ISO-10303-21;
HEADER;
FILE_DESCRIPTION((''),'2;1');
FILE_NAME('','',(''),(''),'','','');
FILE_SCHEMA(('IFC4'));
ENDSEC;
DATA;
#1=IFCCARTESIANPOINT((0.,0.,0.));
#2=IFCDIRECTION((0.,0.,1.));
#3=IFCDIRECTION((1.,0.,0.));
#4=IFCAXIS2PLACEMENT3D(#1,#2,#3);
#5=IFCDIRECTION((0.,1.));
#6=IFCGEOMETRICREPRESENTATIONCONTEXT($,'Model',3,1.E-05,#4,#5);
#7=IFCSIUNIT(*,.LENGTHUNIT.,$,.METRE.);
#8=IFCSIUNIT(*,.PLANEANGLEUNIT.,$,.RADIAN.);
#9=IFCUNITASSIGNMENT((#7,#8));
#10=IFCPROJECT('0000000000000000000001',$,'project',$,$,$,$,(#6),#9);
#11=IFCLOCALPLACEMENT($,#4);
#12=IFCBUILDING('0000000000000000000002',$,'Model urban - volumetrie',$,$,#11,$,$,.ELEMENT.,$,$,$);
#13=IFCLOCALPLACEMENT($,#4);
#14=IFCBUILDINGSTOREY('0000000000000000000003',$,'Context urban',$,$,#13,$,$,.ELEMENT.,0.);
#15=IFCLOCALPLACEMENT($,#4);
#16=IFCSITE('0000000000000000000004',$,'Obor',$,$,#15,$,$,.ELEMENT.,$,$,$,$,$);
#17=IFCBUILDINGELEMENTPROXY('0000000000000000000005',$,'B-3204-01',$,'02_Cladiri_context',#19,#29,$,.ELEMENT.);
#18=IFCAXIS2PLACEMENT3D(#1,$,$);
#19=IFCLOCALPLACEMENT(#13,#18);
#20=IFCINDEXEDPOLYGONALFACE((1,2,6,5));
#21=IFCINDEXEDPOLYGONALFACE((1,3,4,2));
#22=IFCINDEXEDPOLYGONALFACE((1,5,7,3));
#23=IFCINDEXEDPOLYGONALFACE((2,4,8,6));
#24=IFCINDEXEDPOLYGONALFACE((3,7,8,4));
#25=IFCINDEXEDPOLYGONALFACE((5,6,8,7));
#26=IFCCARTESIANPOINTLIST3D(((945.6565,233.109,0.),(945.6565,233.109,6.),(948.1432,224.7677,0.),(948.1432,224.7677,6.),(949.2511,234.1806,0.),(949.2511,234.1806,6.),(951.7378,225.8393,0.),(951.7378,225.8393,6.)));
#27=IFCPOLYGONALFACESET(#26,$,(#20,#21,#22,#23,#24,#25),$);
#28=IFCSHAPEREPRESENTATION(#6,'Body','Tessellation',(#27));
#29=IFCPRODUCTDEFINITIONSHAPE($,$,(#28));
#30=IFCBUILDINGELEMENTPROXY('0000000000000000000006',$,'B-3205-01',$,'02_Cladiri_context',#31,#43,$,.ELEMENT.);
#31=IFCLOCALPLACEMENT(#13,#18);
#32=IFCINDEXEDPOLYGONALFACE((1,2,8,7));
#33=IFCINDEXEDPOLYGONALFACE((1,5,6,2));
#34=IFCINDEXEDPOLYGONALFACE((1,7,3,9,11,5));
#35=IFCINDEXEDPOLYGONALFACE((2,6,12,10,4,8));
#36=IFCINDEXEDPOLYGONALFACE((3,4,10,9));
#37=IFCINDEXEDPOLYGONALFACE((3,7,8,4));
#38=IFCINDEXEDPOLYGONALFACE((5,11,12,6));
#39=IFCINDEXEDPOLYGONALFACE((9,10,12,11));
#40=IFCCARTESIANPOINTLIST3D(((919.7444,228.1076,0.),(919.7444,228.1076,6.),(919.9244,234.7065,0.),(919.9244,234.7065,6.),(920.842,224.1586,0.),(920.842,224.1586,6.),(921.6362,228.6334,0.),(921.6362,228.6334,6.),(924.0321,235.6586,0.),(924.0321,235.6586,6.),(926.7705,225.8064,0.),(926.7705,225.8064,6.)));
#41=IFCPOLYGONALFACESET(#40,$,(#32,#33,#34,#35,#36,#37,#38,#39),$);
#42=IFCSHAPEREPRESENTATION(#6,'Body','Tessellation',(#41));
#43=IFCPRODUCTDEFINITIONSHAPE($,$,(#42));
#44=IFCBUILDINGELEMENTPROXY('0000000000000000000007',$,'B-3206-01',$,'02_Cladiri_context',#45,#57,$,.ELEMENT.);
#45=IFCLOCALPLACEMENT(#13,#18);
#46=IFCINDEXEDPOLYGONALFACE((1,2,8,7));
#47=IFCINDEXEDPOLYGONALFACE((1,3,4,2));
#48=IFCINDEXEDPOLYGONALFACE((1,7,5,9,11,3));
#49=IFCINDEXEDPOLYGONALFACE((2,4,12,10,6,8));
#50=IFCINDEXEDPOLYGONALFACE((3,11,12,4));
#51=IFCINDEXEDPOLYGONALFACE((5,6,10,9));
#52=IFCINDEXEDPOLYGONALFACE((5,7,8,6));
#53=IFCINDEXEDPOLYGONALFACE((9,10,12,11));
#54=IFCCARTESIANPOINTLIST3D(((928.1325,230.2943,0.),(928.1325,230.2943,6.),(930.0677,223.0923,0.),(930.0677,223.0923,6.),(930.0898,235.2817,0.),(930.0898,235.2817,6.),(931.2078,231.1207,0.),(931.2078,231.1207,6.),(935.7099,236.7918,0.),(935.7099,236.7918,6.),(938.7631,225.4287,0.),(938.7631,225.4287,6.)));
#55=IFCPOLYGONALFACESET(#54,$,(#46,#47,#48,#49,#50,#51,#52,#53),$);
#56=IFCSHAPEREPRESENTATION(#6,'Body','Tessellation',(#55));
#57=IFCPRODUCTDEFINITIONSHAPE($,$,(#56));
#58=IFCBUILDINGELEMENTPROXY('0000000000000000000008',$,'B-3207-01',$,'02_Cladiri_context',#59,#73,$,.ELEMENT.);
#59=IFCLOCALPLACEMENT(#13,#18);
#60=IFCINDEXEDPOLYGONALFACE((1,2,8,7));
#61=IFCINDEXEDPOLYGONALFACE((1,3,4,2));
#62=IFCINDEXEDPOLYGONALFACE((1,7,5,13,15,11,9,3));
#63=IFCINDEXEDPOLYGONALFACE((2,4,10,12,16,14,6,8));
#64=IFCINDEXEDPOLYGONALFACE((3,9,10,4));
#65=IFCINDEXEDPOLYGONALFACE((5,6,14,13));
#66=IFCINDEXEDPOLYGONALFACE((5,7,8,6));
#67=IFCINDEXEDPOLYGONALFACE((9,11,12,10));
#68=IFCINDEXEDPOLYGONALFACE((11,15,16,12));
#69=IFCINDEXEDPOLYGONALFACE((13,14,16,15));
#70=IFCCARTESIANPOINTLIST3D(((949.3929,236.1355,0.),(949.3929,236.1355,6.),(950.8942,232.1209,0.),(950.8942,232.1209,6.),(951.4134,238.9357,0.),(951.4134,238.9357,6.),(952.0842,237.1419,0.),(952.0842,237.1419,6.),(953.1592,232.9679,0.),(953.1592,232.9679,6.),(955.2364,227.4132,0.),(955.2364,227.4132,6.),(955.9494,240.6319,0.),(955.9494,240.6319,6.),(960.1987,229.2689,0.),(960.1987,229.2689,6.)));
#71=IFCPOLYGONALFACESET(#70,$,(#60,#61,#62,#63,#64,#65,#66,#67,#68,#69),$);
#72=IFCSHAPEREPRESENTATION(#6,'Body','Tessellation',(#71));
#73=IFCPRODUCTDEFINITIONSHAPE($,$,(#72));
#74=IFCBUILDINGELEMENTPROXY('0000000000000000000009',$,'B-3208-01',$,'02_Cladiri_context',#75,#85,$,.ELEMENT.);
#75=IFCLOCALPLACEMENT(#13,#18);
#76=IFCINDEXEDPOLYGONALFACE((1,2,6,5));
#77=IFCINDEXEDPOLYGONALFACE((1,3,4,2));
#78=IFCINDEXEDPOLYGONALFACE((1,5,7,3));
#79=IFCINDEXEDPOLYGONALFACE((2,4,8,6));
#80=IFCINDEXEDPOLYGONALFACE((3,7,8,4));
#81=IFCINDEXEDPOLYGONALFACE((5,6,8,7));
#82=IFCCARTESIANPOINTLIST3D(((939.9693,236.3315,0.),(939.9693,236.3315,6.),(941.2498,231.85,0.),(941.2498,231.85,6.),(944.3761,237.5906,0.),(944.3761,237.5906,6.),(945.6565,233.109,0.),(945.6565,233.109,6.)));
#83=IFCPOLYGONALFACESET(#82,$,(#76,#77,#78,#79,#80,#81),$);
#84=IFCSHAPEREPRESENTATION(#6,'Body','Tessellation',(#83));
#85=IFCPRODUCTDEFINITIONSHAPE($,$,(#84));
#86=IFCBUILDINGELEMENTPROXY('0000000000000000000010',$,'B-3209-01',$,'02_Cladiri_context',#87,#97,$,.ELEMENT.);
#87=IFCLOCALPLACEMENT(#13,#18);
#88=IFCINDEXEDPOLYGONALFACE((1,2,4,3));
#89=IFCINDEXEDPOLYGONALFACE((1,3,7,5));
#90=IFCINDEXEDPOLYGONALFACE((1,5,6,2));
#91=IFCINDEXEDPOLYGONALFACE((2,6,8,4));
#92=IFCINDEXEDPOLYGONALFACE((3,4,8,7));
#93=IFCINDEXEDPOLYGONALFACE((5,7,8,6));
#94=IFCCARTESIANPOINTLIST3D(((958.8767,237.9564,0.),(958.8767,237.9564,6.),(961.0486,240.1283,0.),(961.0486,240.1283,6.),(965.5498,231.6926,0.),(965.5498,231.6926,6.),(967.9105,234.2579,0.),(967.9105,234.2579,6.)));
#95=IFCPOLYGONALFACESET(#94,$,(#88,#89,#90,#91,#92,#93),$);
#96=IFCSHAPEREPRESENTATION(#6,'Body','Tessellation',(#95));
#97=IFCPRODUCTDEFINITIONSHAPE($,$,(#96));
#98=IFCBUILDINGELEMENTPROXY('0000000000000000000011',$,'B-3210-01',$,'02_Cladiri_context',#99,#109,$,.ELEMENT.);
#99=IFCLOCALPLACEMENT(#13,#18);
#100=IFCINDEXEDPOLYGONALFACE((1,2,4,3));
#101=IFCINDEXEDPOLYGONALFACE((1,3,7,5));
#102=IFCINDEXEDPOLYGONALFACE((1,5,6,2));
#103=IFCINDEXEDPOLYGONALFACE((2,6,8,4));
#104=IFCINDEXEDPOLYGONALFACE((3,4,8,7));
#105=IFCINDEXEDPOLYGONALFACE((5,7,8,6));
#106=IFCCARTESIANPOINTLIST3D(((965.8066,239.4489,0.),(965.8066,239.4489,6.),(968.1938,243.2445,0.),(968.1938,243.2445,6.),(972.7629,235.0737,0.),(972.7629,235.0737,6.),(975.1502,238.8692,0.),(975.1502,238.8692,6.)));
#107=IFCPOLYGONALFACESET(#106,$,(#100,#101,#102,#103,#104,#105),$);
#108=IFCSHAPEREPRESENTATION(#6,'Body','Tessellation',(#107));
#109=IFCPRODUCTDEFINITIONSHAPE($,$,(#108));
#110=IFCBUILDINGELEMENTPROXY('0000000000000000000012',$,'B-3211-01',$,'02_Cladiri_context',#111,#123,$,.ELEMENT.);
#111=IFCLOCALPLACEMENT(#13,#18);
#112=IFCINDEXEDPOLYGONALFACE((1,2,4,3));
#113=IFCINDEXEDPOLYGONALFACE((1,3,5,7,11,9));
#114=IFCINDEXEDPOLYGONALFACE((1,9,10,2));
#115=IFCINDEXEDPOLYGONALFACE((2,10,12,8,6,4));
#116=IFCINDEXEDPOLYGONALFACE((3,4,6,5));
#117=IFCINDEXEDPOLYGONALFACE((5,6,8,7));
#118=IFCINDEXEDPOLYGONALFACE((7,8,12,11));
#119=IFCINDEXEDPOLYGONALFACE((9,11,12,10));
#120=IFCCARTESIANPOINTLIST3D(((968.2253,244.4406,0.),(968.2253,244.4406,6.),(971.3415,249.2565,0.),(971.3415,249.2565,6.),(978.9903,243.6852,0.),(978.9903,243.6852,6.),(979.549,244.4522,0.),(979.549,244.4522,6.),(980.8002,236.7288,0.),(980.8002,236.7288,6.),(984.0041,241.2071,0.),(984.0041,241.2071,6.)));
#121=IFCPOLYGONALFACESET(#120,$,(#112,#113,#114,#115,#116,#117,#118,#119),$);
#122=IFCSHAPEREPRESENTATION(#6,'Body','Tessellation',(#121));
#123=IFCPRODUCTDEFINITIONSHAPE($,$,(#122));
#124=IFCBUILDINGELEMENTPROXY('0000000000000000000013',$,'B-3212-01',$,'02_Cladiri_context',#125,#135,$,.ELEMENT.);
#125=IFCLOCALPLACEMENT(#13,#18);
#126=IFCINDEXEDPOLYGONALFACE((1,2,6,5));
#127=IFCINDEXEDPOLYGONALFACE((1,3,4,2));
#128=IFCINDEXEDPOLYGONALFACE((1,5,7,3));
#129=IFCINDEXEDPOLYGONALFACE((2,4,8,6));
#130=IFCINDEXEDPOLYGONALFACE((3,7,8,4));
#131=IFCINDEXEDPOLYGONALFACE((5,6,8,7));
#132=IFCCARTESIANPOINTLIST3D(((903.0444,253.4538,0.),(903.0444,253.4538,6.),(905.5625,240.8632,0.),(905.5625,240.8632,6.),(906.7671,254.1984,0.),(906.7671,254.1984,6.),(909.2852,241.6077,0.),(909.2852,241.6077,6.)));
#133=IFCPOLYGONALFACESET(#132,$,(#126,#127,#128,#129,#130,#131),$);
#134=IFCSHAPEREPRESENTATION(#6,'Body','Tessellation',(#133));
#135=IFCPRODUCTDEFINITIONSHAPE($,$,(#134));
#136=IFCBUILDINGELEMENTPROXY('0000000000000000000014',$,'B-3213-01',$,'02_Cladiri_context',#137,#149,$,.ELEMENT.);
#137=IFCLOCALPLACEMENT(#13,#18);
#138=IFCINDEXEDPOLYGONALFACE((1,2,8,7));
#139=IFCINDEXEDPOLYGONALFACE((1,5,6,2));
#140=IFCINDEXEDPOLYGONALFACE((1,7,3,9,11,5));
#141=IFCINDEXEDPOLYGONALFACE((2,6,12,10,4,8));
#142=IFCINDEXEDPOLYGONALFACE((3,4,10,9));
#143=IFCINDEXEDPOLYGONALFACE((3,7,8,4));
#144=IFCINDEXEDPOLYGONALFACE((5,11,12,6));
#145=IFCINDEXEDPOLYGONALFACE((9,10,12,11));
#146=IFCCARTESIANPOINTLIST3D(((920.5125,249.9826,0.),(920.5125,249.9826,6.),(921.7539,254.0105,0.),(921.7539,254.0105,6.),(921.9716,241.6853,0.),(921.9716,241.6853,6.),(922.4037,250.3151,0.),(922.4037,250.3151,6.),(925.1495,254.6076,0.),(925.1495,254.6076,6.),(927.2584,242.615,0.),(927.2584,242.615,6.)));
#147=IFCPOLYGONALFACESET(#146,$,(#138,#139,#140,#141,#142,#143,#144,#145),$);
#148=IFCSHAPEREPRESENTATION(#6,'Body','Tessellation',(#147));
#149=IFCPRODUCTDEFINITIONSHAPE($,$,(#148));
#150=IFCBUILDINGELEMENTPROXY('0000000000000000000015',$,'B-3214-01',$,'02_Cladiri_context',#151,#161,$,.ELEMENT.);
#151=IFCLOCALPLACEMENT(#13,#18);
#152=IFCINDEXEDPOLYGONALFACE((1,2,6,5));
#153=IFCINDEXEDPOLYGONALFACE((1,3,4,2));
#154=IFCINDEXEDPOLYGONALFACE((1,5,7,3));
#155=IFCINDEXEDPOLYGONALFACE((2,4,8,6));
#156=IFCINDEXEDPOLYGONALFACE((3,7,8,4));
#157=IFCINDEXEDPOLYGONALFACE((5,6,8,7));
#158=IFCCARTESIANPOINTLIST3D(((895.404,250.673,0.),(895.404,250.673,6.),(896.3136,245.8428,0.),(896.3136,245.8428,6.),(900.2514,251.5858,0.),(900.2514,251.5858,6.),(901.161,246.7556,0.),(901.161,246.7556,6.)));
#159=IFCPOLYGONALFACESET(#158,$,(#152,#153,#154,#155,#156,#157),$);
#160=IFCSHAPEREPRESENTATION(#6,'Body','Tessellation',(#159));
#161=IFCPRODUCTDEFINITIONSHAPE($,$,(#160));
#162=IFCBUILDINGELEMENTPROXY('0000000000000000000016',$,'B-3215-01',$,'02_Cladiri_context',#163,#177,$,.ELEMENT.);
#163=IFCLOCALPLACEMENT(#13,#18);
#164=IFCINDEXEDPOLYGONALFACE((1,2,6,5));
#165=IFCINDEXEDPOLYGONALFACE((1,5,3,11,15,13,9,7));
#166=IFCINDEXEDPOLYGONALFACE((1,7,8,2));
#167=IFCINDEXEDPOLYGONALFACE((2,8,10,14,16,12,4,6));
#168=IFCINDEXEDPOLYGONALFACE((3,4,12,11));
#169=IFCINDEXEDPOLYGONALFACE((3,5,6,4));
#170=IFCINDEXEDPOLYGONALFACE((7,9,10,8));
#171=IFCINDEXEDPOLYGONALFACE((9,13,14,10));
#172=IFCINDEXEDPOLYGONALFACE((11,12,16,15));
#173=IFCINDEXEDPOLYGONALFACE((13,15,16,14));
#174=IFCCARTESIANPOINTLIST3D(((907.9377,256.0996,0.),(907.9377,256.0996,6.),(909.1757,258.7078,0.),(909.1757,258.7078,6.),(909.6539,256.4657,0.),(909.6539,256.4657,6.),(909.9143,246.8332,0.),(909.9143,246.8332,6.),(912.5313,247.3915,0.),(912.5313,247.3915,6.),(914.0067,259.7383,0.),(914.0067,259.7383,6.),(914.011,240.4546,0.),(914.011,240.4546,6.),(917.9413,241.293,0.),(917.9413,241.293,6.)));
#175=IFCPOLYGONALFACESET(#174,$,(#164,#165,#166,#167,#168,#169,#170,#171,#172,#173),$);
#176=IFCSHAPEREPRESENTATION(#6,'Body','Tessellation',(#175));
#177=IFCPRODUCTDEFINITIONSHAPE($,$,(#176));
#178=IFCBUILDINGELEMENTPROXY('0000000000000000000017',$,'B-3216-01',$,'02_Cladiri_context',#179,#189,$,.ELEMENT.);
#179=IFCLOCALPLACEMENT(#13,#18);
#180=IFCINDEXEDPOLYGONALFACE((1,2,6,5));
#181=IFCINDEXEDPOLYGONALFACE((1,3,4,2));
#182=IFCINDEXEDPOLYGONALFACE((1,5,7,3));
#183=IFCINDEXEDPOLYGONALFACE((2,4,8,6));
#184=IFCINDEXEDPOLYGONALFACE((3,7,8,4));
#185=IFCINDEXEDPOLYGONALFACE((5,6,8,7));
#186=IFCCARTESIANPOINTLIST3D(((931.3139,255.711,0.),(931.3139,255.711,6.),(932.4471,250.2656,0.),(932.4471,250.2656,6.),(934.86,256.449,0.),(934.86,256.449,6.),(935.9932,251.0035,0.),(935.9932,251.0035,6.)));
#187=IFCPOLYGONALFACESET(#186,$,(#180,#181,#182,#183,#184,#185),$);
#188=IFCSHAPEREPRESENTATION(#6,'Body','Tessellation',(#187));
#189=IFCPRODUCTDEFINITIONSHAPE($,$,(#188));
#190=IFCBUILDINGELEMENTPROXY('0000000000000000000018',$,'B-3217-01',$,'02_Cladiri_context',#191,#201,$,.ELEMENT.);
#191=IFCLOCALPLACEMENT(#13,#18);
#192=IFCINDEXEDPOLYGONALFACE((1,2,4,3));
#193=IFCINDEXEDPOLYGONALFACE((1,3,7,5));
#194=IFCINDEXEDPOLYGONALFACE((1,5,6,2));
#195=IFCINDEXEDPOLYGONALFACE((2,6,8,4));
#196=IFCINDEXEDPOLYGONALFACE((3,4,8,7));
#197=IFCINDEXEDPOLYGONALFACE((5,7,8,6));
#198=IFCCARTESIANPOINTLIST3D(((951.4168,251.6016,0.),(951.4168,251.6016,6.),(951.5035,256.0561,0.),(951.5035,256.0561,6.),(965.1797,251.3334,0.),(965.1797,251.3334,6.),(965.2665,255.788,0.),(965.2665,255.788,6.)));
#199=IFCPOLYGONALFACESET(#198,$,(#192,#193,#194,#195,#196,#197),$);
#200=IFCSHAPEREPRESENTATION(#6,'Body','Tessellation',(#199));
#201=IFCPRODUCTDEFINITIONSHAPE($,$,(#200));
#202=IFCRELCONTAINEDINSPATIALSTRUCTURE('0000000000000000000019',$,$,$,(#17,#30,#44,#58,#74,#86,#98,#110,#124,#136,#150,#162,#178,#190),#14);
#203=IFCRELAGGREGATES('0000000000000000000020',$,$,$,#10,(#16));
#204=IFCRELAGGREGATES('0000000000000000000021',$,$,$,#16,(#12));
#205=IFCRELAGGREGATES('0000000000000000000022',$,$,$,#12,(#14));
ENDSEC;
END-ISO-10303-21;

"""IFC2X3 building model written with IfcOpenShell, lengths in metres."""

from ifc_helpers import new_model, si_unit, direction, origin_with_axes, place, context, project, spatial, polyline, outline, extrude, element, save


model = new_model("IFC2X3")

# Units and contexts
model_context = context("Model", 3, precision=1e-05, world=origin_with_axes(), true_north=direction((0.0, 1.0)))
ifc_project = project(units=[si_unit("LENGTHUNIT", "METRE"), si_unit("PLANEANGLEUNIT", "RADIAN")], contexts=[model_context])

# Site, building, storey
site_placement = place(None, origin_with_axes())
site = spatial("IfcSite", under=ifc_project, at=site_placement, Name="Obor", CompositionType="ELEMENT")
building_placement = place(None, origin_with_axes())
building = spatial("IfcBuilding", under=site, at=building_placement, Name="Model urban - volumetrie", CompositionType="ELEMENT")
storey_placement = place(None, origin_with_axes())
storey = spatial("IfcBuildingStorey", under=building, at=storey_placement, Name="Context urban", CompositionType="ELEMENT", Elevation=0.0)

# Building element proxies
proxy_1_placement = place(None, origin_with_axes())
element("IfcBuildingElementProxy", 1, at=proxy_1_placement, inside=storey, Name="B-3204-01", ObjectType="02_Cladiri_context", CompositionType="ELEMENT", context=model_context, shape_type="SweptSolid", body=[
    extrude(outline(polyline([(951.7378, 225.8393), (949.2511, 234.1806), (945.6565, 233.109), (948.1432, 224.7677), (951.7378, 225.8393)])), origin_with_axes(), (0.0, 0.0, 1.0), 6.0),
])
proxy_2_placement = place(None, origin_with_axes())
element("IfcBuildingElementProxy", 2, at=proxy_2_placement, inside=storey, Name="B-3205-01", ObjectType="02_Cladiri_context", CompositionType="ELEMENT", context=model_context, shape_type="SweptSolid", body=[
    extrude(outline(polyline([(920.842, 224.1586), (926.7705, 225.8064), (924.0321, 235.6586), (919.9244, 234.7065), (921.6362, 228.6334), (919.7444, 228.1076), (920.842, 224.1586)])), origin_with_axes(), (0.0, 0.0, 1.0), 6.0),
])
proxy_3_placement = place(None, origin_with_axes())
element("IfcBuildingElementProxy", 3, at=proxy_3_placement, inside=storey, Name="B-3206-01", ObjectType="02_Cladiri_context", CompositionType="ELEMENT", context=model_context, shape_type="SweptSolid", body=[
    extrude(outline(polyline([(928.1325, 230.2943), (930.0677, 223.0923), (938.7631, 225.4287), (935.7099, 236.7918), (930.0898, 235.2817), (931.2078, 231.1207), (928.1325, 230.2943)])), origin_with_axes(), (0.0, 0.0, 1.0), 6.0),
])
proxy_4_placement = place(None, origin_with_axes())
element("IfcBuildingElementProxy", 4, at=proxy_4_placement, inside=storey, Name="B-3207-01", ObjectType="02_Cladiri_context", CompositionType="ELEMENT", context=model_context, shape_type="SweptSolid", body=[
    extrude(outline(polyline([(951.4134, 238.9357), (952.0842, 237.1419), (949.3929, 236.1355), (950.8942, 232.1209), (953.1592, 232.9679), (955.2364, 227.4132), (960.1987, 229.2689), (955.9494, 240.6319), (951.4134, 238.9357)])), origin_with_axes(), (0.0, 0.0, 1.0), 6.0),
])
proxy_5_placement = place(None, origin_with_axes())
element("IfcBuildingElementProxy", 5, at=proxy_5_placement, inside=storey, Name="B-3208-01", ObjectType="02_Cladiri_context", CompositionType="ELEMENT", context=model_context, shape_type="SweptSolid", body=[
    extrude(outline(polyline([(939.9693, 236.3315), (941.2498, 231.85), (945.6565, 233.109), (944.3761, 237.5906), (939.9693, 236.3315)])), origin_with_axes(), (0.0, 0.0, 1.0), 6.0),
])
proxy_6_placement = place(None, origin_with_axes())
element("IfcBuildingElementProxy", 6, at=proxy_6_placement, inside=storey, Name="B-3209-01", ObjectType="02_Cladiri_context", CompositionType="ELEMENT", context=model_context, shape_type="SweptSolid", body=[
    extrude(outline(polyline([(967.9105, 234.2579), (961.0486, 240.1283), (958.8767, 237.9564), (965.5498, 231.6926), (967.9105, 234.2579)])), origin_with_axes(), (0.0, 0.0, 1.0), 6.0),
])
proxy_7_placement = place(None, origin_with_axes())
element("IfcBuildingElementProxy", 7, at=proxy_7_placement, inside=storey, Name="B-3210-01", ObjectType="02_Cladiri_context", CompositionType="ELEMENT", context=model_context, shape_type="SweptSolid", body=[
    extrude(outline(polyline([(972.7629, 235.0737), (975.1502, 238.8692), (968.1938, 243.2445), (965.8066, 239.4489), (972.7629, 235.0737)])), origin_with_axes(), (0.0, 0.0, 1.0), 6.0),
])
proxy_8_placement = place(None, origin_with_axes())
element("IfcBuildingElementProxy", 8, at=proxy_8_placement, inside=storey, Name="B-3211-01", ObjectType="02_Cladiri_context", CompositionType="ELEMENT", context=model_context, shape_type="SweptSolid", body=[
    extrude(outline(polyline([(984.0041, 241.2071), (979.549, 244.4522), (978.9903, 243.6852), (971.3415, 249.2565), (968.2253, 244.4406), (980.8002, 236.7288), (984.0041, 241.2071)])), origin_with_axes(), (0.0, 0.0, 1.0), 6.0),
])
proxy_9_placement = place(None, origin_with_axes())
element("IfcBuildingElementProxy", 9, at=proxy_9_placement, inside=storey, Name="B-3212-01", ObjectType="02_Cladiri_context", CompositionType="ELEMENT", context=model_context, shape_type="SweptSolid", body=[
    extrude(outline(polyline([(903.0444, 253.4538), (905.5625, 240.8632), (909.2852, 241.6077), (906.7671, 254.1984), (903.0444, 253.4538)])), origin_with_axes(), (0.0, 0.0, 1.0), 6.0),
])
proxy_10_placement = place(None, origin_with_axes())
element("IfcBuildingElementProxy", 10, at=proxy_10_placement, inside=storey, Name="B-3213-01", ObjectType="02_Cladiri_context", CompositionType="ELEMENT", context=model_context, shape_type="SweptSolid", body=[
    extrude(outline(polyline([(921.9716, 241.6853), (927.2584, 242.615), (925.1495, 254.6076), (921.7539, 254.0105), (922.4037, 250.3151), (920.5125, 249.9826), (921.9716, 241.6853)])), origin_with_axes(), (0.0, 0.0, 1.0), 6.0),
])
proxy_11_placement = place(None, origin_with_axes())
element("IfcBuildingElementProxy", 11, at=proxy_11_placement, inside=storey, Name="B-3214-01", ObjectType="02_Cladiri_context", CompositionType="ELEMENT", context=model_context, shape_type="SweptSolid", body=[
    extrude(outline(polyline([(901.161, 246.7556), (900.2514, 251.5858), (895.404, 250.673), (896.3136, 245.8428), (901.161, 246.7556)])), origin_with_axes(), (0.0, 0.0, 1.0), 6.0),
])
proxy_12_placement = place(None, origin_with_axes())
element("IfcBuildingElementProxy", 12, at=proxy_12_placement, inside=storey, Name="B-3215-01", ObjectType="02_Cladiri_context", CompositionType="ELEMENT", context=model_context, shape_type="SweptSolid", body=[
    extrude(outline(polyline([(909.6539, 256.4657), (907.9377, 256.0996), (909.9143, 246.8332), (912.5313, 247.3915), (914.011, 240.4546), (917.9413, 241.293), (914.0067, 259.7383), (909.1757, 258.7078), (909.6539, 256.4657)])), origin_with_axes(), (0.0, 0.0, 1.0), 6.0),
])
proxy_13_placement = place(None, origin_with_axes())
element("IfcBuildingElementProxy", 13, at=proxy_13_placement, inside=storey, Name="B-3216-01", ObjectType="02_Cladiri_context", CompositionType="ELEMENT", context=model_context, shape_type="SweptSolid", body=[
    extrude(outline(polyline([(931.3139, 255.711), (932.4471, 250.2656), (935.9932, 251.0035), (934.86, 256.449), (931.3139, 255.711)])), origin_with_axes(), (0.0, 0.0, 1.0), 6.0),
])
proxy_14_placement = place(None, origin_with_axes())
element("IfcBuildingElementProxy", 14, at=proxy_14_placement, inside=storey, Name="B-3217-01", ObjectType="02_Cladiri_context", CompositionType="ELEMENT", context=model_context, shape_type="SweptSolid", body=[
    extrude(outline(polyline([(951.4168, 251.6016), (965.1797, 251.3334), (965.2665, 255.788), (951.5035, 256.0561), (951.4168, 251.6016)])), origin_with_axes(), (0.0, 0.0, 1.0), 6.0),
])

save(model, "model.ifc")
